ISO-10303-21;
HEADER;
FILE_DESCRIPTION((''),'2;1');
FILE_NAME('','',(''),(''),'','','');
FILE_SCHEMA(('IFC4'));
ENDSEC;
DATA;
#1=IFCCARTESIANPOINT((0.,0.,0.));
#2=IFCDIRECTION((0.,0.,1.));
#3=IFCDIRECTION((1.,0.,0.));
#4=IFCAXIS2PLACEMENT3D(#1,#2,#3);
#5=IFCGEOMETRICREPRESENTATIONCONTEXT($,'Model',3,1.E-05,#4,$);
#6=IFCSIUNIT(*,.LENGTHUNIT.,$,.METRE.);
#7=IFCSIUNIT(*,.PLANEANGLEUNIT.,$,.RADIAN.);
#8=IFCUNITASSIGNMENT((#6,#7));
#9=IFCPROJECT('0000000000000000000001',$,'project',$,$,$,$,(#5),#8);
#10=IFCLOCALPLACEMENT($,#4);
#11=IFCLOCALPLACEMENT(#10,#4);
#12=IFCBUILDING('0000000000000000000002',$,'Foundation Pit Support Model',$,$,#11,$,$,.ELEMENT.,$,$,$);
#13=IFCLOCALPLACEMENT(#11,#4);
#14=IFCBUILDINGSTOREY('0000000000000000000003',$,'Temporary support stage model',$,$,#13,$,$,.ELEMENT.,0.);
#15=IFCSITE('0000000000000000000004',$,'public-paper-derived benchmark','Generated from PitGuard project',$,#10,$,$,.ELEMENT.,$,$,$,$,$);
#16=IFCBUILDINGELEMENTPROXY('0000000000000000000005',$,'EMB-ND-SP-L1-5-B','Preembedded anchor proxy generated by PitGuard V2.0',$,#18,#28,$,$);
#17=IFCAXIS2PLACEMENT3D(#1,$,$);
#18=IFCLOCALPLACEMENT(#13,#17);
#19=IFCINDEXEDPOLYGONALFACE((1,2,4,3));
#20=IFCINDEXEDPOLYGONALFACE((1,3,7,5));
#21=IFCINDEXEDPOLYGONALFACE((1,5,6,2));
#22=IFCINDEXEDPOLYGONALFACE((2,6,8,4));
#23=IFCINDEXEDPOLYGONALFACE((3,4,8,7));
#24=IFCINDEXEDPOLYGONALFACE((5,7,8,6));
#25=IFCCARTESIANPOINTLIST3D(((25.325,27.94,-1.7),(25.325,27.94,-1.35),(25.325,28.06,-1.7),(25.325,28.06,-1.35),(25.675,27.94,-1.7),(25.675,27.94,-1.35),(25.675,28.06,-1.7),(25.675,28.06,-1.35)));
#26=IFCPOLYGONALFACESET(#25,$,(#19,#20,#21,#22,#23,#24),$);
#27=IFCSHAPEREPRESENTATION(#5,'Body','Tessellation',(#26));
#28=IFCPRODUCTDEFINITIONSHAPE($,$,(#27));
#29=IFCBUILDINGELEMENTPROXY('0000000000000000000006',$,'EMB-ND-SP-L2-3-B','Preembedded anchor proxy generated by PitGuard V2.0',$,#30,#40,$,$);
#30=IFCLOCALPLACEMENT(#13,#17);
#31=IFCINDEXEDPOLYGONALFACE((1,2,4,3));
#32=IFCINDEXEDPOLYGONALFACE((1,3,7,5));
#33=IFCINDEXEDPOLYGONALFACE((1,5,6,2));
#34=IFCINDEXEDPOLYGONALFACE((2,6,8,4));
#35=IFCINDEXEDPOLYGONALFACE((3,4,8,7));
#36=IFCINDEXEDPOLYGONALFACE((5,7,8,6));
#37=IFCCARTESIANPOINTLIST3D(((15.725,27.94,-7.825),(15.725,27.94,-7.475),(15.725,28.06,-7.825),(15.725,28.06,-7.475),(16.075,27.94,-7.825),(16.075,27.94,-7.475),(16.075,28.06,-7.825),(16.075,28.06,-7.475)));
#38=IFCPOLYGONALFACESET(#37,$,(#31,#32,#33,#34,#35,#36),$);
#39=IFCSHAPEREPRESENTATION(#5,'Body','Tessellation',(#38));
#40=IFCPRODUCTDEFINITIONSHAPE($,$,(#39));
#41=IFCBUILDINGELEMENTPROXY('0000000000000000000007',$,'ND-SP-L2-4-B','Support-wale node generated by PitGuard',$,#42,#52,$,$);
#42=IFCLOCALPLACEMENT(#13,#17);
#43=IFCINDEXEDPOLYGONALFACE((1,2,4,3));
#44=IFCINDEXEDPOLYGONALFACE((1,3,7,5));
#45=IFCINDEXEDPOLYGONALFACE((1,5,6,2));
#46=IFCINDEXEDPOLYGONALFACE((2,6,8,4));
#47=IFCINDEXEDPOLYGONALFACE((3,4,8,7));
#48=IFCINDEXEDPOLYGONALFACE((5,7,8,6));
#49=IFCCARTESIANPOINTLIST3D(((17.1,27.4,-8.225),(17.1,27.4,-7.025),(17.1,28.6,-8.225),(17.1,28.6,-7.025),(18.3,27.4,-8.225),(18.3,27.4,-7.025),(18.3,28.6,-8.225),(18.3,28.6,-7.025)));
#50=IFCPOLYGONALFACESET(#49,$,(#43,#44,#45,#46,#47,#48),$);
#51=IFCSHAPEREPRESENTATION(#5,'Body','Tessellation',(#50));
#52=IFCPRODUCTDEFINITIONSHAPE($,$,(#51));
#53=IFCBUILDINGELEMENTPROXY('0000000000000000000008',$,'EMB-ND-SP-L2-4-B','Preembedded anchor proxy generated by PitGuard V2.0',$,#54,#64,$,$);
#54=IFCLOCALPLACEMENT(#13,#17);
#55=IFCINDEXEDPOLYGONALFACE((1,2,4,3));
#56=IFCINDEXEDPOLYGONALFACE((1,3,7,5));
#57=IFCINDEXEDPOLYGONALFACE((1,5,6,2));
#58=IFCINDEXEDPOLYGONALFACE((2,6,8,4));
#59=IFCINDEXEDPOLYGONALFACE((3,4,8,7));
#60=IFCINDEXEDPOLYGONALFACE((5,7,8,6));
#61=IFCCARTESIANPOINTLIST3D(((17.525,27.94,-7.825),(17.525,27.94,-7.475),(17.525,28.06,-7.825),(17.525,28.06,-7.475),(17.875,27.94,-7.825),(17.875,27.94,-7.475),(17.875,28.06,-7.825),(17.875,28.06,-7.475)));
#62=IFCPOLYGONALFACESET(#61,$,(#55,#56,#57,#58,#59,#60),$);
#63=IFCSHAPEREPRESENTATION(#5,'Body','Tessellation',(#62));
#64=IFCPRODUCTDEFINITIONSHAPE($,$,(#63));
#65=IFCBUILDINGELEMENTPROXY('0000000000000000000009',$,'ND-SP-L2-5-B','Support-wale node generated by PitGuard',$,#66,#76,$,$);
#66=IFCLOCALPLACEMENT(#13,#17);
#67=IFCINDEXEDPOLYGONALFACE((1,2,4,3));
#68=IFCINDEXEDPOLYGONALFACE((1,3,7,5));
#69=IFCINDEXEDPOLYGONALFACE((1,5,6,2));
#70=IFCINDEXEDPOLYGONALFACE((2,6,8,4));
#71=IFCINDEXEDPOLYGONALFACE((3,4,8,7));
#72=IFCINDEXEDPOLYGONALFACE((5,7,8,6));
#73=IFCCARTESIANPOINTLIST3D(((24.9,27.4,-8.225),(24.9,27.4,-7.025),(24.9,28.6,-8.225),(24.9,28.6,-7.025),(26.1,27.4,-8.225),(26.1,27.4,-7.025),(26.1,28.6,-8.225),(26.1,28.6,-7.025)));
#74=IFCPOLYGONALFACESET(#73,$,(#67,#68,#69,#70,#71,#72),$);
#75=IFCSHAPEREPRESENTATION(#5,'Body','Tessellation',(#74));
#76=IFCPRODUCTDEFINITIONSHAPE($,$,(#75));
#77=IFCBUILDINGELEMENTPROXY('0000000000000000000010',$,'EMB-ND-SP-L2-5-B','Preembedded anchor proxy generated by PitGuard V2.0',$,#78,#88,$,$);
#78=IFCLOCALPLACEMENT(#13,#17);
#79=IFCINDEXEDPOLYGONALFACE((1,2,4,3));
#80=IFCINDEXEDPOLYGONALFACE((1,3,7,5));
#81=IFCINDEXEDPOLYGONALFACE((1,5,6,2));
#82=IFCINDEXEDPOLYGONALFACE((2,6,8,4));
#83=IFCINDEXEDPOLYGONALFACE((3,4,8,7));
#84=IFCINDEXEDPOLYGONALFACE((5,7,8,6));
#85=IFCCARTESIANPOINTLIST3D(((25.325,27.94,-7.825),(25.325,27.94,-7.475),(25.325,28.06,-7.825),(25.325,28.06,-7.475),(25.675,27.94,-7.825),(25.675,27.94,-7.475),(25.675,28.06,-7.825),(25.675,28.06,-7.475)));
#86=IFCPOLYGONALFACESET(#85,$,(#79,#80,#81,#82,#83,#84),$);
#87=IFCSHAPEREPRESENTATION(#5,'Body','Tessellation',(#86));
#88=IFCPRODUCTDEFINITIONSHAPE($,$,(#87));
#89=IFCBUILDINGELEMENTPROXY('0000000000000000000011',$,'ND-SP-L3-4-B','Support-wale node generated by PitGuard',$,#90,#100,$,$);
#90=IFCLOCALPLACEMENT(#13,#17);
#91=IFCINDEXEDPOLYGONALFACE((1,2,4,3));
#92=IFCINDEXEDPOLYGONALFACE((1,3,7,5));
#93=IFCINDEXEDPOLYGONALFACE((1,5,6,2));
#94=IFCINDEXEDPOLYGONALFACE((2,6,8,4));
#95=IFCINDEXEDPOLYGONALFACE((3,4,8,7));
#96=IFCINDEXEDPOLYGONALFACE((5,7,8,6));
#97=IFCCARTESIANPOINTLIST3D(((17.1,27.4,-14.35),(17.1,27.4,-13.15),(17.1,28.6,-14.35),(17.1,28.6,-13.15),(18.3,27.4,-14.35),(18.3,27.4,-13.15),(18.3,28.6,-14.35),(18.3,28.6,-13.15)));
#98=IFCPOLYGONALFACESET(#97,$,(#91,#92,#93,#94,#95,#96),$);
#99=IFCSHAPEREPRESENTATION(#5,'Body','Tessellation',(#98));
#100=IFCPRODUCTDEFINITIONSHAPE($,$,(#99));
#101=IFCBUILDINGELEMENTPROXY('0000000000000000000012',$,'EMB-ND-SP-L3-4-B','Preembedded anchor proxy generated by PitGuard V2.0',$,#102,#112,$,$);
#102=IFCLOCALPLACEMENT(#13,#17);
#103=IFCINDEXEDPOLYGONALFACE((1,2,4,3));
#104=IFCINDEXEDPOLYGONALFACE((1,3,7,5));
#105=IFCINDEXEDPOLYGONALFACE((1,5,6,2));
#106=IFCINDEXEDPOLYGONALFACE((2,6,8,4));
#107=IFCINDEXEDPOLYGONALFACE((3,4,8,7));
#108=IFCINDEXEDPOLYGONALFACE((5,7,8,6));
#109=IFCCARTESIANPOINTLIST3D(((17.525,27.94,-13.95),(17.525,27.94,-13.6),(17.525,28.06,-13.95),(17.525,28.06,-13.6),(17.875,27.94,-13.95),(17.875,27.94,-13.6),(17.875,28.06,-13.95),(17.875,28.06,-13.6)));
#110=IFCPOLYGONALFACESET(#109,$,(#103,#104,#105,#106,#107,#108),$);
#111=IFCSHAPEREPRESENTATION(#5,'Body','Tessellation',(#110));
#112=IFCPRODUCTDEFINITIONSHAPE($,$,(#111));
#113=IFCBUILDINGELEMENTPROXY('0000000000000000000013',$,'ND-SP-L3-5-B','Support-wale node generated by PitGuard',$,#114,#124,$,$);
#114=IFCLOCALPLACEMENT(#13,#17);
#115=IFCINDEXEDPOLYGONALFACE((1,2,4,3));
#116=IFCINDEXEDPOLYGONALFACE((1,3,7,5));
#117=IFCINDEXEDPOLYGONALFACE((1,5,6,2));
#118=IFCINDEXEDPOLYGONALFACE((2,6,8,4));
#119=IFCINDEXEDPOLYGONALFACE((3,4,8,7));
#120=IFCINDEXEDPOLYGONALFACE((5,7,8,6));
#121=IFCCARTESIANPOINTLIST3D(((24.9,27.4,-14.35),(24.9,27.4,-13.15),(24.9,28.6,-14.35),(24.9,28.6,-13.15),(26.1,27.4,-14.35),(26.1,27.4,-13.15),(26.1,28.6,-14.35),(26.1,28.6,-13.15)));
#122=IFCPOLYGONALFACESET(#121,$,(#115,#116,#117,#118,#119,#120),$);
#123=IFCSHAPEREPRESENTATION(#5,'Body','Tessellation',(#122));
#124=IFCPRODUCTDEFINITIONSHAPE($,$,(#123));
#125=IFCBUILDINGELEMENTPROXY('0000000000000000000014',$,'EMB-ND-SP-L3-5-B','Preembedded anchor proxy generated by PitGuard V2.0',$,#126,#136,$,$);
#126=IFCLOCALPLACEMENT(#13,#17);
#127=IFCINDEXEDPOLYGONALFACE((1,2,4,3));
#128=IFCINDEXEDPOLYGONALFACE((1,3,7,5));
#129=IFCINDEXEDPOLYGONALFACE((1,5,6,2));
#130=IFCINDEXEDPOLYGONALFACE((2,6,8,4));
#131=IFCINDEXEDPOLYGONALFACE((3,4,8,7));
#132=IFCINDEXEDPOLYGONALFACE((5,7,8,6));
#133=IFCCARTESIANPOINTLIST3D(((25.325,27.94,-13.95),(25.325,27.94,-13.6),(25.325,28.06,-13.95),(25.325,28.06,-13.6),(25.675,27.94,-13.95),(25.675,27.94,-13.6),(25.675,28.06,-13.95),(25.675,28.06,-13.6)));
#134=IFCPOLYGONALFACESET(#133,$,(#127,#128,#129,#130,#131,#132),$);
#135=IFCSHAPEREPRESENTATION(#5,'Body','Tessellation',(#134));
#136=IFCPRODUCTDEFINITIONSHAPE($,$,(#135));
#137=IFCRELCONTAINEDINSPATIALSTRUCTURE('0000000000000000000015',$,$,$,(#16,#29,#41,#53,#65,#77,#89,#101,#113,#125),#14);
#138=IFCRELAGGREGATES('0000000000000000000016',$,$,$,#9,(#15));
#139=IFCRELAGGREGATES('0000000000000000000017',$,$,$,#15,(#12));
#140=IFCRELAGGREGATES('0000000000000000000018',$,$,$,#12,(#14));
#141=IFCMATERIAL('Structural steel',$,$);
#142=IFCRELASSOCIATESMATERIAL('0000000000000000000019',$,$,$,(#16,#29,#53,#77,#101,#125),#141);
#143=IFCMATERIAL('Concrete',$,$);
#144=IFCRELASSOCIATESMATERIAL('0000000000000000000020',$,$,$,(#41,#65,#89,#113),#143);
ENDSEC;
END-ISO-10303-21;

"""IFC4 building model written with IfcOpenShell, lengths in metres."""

from ifc_helpers import new_model, si_unit, frame, origin_with_axes, origin_2d, place, context, project, spatial, rectangle, extrude, material, element, save


model = new_model("IFC4")

# Units and contexts
model_context = context("Model", 3, precision=1e-05, world=origin_with_axes())
ifc_project = project(units=[si_unit("LENGTHUNIT", "METRE"), si_unit("PLANEANGLEUNIT", "RADIAN")], contexts=[model_context])

# Site, building, storey
site_placement = place(None, origin_with_axes())
site = spatial("IfcSite", under=ifc_project, at=site_placement, Name="public-paper-derived benchmark", Description="Generated from PitGuard project", CompositionType="ELEMENT")
building_placement = place(site_placement, origin_with_axes())
building = spatial("IfcBuilding", under=site, at=building_placement, Name="Foundation Pit Support Model", CompositionType="ELEMENT")
storey_placement = place(building_placement, origin_with_axes())
storey = spatial("IfcBuildingStorey", under=building, at=storey_placement, Name="Temporary support stage model", CompositionType="ELEMENT", Elevation=0.0)

# Shared definitions
ifc_material_1 = material(Name="Structural steel")

# Building element proxies
ifc_material_2 = material(Name="Concrete")
for number, where, z_axis, x_axis, name in (
    (1, (25.5, 28.0, -1.7), (0.0, 0.0, 1.0), (1.0, 0.0, 0.0), "EMB-ND-SP-L1-5-B"),
    (2, (15.9, 28.0, -7.825), (0.0, 0.0, 1.0), (1.0, 0.0, 0.0), "EMB-ND-SP-L2-3-B"),
):
    element("IfcBuildingElementProxy", number, at=place(storey_placement, frame(where, z_axis=z_axis, x_axis=x_axis)), inside=storey, material=ifc_material_1, Name=name, Description="Preembedded anchor proxy generated by PitGuard V2.0", context=model_context, shape_type="SweptSolid", body=[
        extrude(rectangle(XDim=0.35, YDim=0.12, at=origin_2d()), origin_with_axes(), (0.0, 0.0, 1.0), 0.35),
    ])
proxy_1_placement = place(storey_placement, frame((17.7, 28.0, -8.225), z_axis=(0.0, 0.0, 1.0), x_axis=(1.0, 0.0, 0.0)))
element("IfcBuildingElementProxy", 3, at=proxy_1_placement, inside=storey, material=ifc_material_2, Name="ND-SP-L2-4-B", Description="Support-wale node generated by PitGuard", context=model_context, shape_type="SweptSolid", body=[
    extrude(rectangle(XDim=1.2, YDim=1.2, at=origin_2d()), origin_with_axes(), (0.0, 0.0, 1.0), 1.2),
])
proxy_2_placement = place(storey_placement, frame((17.7, 28.0, -7.825), z_axis=(0.0, 0.0, 1.0), x_axis=(1.0, 0.0, 0.0)))
element("IfcBuildingElementProxy", 4, at=proxy_2_placement, inside=storey, material=ifc_material_1, Name="EMB-ND-SP-L2-4-B", Description="Preembedded anchor proxy generated by PitGuard V2.0", context=model_context, shape_type="SweptSolid", body=[
    extrude(rectangle(XDim=0.35, YDim=0.12, at=origin_2d()), origin_with_axes(), (0.0, 0.0, 1.0), 0.35),
])
proxy_3_placement = place(storey_placement, frame((25.5, 28.0, -8.225), z_axis=(0.0, 0.0, 1.0), x_axis=(1.0, 0.0, 0.0)))
element("IfcBuildingElementProxy", 5, at=proxy_3_placement, inside=storey, material=ifc_material_2, Name="ND-SP-L2-5-B", Description="Support-wale node generated by PitGuard", context=model_context, shape_type="SweptSolid", body=[
    extrude(rectangle(XDim=1.2, YDim=1.2, at=origin_2d()), origin_with_axes(), (0.0, 0.0, 1.0), 1.2),
])
proxy_4_placement = place(storey_placement, frame((25.5, 28.0, -7.825), z_axis=(0.0, 0.0, 1.0), x_axis=(1.0, 0.0, 0.0)))
element("IfcBuildingElementProxy", 6, at=proxy_4_placement, inside=storey, material=ifc_material_1, Name="EMB-ND-SP-L2-5-B", Description="Preembedded anchor proxy generated by PitGuard V2.0", context=model_context, shape_type="SweptSolid", body=[
    extrude(rectangle(XDim=0.35, YDim=0.12, at=origin_2d()), origin_with_axes(), (0.0, 0.0, 1.0), 0.35),
])
proxy_5_placement = place(storey_placement, frame((17.7, 28.0, -14.35), z_axis=(0.0, 0.0, 1.0), x_axis=(1.0, 0.0, 0.0)))
element("IfcBuildingElementProxy", 7, at=proxy_5_placement, inside=storey, material=ifc_material_2, Name="ND-SP-L3-4-B", Description="Support-wale node generated by PitGuard", context=model_context, shape_type="SweptSolid", body=[
    extrude(rectangle(XDim=1.2, YDim=1.2, at=origin_2d()), origin_with_axes(), (0.0, 0.0, 1.0), 1.2),
])
proxy_6_placement = place(storey_placement, frame((17.7, 28.0, -13.95), z_axis=(0.0, 0.0, 1.0), x_axis=(1.0, 0.0, 0.0)))
element("IfcBuildingElementProxy", 8, at=proxy_6_placement, inside=storey, material=ifc_material_1, Name="EMB-ND-SP-L3-4-B", Description="Preembedded anchor proxy generated by PitGuard V2.0", context=model_context, shape_type="SweptSolid", body=[
    extrude(rectangle(XDim=0.35, YDim=0.12, at=origin_2d()), origin_with_axes(), (0.0, 0.0, 1.0), 0.35),
])
proxy_7_placement = place(storey_placement, frame((25.5, 28.0, -14.35), z_axis=(0.0, 0.0, 1.0), x_axis=(1.0, 0.0, 0.0)))
element("IfcBuildingElementProxy", 9, at=proxy_7_placement, inside=storey, material=ifc_material_2, Name="ND-SP-L3-5-B", Description="Support-wale node generated by PitGuard", context=model_context, shape_type="SweptSolid", body=[
    extrude(rectangle(XDim=1.2, YDim=1.2, at=origin_2d()), origin_with_axes(), (0.0, 0.0, 1.0), 1.2),
])
proxy_8_placement = place(storey_placement, frame((25.5, 28.0, -13.95), z_axis=(0.0, 0.0, 1.0), x_axis=(1.0, 0.0, 0.0)))
element("IfcBuildingElementProxy", 10, at=proxy_8_placement, inside=storey, material=ifc_material_1, Name="EMB-ND-SP-L3-5-B", Description="Preembedded anchor proxy generated by PitGuard V2.0", context=model_context, shape_type="SweptSolid", body=[
    extrude(rectangle(XDim=0.35, YDim=0.12, at=origin_2d()), origin_with_axes(), (0.0, 0.0, 1.0), 0.35),
])

save(model, "model.ifc")
